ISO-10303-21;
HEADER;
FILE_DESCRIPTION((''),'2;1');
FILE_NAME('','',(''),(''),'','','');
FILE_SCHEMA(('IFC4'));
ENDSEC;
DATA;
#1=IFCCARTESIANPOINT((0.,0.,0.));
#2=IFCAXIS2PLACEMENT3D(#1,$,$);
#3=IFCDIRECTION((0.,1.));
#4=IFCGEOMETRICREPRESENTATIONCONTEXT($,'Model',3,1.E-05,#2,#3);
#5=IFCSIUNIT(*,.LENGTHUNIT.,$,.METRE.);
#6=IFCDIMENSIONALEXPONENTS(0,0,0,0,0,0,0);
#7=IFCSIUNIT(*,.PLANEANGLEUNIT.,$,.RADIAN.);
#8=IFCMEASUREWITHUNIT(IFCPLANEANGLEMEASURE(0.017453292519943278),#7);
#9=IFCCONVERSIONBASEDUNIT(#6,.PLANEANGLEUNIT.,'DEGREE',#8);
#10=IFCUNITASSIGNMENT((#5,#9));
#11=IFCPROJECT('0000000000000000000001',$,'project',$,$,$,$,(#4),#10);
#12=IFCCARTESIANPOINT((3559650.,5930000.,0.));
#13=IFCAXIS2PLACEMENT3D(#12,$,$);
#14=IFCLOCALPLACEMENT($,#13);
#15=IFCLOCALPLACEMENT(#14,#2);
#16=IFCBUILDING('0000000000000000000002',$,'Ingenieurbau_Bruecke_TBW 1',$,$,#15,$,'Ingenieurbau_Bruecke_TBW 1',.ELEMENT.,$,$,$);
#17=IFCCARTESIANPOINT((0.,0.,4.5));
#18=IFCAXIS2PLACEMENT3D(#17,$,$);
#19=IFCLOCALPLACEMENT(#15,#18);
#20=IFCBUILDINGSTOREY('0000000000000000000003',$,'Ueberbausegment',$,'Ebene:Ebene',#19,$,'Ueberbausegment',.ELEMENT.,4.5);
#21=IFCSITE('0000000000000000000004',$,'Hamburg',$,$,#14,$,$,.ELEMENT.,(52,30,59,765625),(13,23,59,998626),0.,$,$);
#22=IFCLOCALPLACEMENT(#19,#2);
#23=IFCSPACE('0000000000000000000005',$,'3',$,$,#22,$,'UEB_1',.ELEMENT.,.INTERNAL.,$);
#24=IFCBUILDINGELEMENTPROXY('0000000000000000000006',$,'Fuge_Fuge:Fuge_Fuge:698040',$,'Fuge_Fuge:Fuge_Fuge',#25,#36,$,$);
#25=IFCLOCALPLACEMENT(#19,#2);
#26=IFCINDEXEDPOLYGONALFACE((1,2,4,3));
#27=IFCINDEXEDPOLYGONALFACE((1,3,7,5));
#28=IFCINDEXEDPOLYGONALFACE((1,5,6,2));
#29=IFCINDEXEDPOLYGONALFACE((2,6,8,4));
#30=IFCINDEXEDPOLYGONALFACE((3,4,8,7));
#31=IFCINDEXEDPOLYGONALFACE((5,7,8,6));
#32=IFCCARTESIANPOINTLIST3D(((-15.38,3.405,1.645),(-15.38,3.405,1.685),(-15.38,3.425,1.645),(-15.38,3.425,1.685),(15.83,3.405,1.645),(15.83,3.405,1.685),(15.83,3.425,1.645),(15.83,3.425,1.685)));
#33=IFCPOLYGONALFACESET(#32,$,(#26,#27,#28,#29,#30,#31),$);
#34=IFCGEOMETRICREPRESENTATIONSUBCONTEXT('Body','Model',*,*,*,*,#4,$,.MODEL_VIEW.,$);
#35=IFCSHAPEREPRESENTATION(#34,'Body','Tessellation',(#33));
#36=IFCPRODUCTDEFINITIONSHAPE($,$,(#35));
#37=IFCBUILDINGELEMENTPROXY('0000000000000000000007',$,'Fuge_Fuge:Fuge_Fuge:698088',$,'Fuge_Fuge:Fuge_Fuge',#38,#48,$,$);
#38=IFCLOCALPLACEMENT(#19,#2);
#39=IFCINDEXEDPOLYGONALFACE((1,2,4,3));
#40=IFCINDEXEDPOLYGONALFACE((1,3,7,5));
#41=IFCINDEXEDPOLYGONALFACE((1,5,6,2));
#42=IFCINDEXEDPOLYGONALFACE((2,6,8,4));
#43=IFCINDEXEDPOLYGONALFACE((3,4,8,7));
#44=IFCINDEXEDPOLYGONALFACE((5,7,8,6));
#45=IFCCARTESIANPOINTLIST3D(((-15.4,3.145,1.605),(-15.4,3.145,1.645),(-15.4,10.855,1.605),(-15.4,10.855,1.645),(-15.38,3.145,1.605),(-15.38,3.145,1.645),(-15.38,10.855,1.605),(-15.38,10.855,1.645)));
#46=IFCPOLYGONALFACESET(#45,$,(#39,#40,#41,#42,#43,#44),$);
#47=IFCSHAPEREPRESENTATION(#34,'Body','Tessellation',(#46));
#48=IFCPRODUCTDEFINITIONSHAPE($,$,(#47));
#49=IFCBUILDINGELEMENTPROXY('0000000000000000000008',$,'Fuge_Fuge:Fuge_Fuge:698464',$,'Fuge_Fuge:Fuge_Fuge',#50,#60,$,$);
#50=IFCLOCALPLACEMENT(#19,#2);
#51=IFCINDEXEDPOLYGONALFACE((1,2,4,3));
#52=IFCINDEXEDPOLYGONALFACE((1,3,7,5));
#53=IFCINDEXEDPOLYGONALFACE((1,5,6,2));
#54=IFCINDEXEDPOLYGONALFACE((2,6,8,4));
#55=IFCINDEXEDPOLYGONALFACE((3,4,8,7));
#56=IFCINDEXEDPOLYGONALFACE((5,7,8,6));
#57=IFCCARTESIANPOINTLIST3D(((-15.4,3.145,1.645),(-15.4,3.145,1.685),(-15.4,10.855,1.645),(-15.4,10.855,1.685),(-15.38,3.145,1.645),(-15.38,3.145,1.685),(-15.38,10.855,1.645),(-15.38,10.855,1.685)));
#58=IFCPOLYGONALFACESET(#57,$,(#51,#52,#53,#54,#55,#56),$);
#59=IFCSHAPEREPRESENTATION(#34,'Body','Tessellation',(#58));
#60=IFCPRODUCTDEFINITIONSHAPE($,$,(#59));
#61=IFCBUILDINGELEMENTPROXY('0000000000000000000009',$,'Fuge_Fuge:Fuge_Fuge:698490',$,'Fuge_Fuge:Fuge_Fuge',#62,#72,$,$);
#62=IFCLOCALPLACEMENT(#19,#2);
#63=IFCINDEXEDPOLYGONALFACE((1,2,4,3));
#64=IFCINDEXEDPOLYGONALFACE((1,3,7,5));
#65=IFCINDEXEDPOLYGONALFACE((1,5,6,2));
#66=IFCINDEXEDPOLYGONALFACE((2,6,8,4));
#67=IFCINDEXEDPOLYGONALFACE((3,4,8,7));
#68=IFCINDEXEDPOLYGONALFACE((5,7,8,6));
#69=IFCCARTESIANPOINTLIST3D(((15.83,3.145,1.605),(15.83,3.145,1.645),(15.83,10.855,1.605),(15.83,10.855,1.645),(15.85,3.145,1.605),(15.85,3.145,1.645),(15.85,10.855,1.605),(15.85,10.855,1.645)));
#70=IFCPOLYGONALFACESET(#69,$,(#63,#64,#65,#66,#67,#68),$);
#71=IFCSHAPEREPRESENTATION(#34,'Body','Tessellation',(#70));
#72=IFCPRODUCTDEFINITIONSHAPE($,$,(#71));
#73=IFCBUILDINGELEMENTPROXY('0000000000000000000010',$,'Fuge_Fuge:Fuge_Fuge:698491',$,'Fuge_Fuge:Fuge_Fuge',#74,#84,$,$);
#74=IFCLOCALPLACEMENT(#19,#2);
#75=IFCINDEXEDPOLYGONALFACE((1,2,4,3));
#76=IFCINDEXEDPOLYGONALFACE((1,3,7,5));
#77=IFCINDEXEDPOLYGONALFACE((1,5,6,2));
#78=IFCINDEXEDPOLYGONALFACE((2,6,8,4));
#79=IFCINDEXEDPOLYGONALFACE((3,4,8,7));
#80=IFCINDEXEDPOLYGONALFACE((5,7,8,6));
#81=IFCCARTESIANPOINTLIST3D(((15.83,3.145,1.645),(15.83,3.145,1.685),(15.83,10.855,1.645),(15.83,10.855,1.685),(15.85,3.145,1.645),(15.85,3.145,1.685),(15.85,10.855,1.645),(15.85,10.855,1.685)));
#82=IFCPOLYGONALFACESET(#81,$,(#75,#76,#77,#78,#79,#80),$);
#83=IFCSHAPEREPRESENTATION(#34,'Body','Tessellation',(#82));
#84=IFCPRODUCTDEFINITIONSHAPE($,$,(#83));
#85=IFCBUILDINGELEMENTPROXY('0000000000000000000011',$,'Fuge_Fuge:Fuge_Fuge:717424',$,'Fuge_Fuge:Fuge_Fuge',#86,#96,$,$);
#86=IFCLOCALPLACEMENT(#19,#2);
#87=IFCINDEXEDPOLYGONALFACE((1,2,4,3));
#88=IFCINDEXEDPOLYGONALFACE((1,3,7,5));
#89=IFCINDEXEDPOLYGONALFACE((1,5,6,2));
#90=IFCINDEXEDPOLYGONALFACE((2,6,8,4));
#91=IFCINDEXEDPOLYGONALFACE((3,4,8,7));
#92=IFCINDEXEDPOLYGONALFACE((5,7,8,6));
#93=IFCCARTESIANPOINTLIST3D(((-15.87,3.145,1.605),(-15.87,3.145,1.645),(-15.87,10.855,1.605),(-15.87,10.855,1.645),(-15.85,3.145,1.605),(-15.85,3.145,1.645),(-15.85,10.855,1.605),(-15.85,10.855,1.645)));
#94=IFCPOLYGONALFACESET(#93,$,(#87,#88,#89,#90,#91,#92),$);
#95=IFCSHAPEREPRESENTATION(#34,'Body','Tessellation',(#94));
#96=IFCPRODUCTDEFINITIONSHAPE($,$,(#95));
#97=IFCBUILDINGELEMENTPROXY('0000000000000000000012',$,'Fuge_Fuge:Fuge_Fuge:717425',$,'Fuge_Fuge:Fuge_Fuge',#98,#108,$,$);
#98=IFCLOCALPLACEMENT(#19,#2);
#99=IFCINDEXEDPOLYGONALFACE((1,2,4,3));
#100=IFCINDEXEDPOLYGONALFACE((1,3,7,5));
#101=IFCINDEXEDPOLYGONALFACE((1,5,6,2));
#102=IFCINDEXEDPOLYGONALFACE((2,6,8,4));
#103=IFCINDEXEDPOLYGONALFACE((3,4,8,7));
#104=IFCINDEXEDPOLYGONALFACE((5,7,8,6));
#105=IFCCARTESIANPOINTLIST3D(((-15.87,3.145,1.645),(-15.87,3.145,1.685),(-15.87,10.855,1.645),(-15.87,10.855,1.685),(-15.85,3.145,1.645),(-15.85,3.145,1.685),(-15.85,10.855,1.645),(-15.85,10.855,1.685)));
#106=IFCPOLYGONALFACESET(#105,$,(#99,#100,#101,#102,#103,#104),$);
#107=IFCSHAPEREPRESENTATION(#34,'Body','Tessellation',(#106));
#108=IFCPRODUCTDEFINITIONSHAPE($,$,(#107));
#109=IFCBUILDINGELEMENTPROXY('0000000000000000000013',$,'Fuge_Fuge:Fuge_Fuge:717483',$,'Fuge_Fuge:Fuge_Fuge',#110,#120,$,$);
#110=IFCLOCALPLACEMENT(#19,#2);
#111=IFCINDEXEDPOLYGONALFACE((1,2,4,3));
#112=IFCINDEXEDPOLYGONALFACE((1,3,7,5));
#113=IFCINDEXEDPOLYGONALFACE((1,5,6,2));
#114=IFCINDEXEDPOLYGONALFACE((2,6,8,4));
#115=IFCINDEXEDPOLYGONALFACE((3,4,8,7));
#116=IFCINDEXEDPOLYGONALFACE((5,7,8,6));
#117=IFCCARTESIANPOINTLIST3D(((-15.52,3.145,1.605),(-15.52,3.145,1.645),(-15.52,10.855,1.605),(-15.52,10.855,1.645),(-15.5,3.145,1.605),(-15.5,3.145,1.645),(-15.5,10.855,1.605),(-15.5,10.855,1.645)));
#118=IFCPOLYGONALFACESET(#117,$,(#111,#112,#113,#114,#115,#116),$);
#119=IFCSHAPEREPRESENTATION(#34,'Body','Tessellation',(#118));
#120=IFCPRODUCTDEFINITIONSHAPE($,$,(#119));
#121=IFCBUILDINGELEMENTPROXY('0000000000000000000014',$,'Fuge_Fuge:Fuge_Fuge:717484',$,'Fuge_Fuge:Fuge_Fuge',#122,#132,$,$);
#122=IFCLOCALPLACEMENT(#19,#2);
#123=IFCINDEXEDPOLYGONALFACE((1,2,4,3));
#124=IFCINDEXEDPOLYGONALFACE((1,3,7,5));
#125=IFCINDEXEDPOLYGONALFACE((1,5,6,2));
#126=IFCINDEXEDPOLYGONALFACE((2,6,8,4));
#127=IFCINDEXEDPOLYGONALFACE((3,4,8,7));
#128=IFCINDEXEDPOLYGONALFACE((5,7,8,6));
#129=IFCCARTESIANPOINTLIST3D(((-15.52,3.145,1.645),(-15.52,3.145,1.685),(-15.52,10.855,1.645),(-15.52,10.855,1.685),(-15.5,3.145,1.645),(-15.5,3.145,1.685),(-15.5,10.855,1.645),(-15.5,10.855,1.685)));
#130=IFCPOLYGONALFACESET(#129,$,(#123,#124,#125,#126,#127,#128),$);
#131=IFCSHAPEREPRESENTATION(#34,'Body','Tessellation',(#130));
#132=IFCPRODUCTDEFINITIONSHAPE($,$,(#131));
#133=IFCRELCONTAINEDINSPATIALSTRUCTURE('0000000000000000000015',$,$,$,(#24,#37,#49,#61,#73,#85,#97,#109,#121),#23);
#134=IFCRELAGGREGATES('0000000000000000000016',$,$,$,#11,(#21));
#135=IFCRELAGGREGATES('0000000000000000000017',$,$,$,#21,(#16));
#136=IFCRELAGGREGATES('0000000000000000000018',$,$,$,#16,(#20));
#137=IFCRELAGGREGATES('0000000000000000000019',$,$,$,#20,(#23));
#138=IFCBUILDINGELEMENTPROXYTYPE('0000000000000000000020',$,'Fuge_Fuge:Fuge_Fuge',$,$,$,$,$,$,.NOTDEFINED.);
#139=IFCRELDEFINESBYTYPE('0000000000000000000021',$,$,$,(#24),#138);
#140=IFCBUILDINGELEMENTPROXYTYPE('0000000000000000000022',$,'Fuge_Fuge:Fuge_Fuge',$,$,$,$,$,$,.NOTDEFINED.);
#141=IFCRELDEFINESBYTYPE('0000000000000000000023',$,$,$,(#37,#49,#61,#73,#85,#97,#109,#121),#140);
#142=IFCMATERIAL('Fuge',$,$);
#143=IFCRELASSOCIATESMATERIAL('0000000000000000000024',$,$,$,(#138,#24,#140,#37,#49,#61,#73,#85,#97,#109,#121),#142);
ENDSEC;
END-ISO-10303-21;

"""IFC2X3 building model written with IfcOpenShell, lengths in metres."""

from ifc_helpers import new_model, entity, si_unit, converted_unit, direction, frame, frame_2d, origin, place, context, subcontext, project, spatial, rectangle, extrude, source, transform, mapped, material, type_object, type_shapes, element, save


model = new_model("IFC2X3")

# Units and contexts
model_context = context("Model", 3, precision=1e-05, world=origin(), true_north=direction((0.0, 1.0)))
body_context = subcontext(model_context, "Body", "Model", "MODEL_VIEW")
ifc_project = project(units=[si_unit("LENGTHUNIT", "METRE"), converted_unit("PLANEANGLEUNIT", "DEGREE", entity("IfcPlaneAngleMeasure", 0.017453292519943278), si_unit("PLANEANGLEUNIT", "RADIAN"), dimensions=[0, 0, 0, 0, 0, 0, 0])], contexts=[model_context])

# Site, building, storey, space
site_placement = place(None, frame((3559650.0, 5930000.0, 0.0)))
site = spatial("IfcSite", under=ifc_project, at=site_placement, Name="Hamburg", CompositionType="ELEMENT", RefLatitude=(52, 30, 59, 765625), RefLongitude=(13, 23, 59, 998626), RefElevation=0.0)
building_placement = place(site_placement, origin())
building = spatial("IfcBuilding", under=site, at=building_placement, Name="Ingenieurbau_Bruecke_TBW 1", LongName="Ingenieurbau_Bruecke_TBW 1", CompositionType="ELEMENT")
storey_placement = place(building_placement, frame((0.0, 0.0, 4.5)))
storey = spatial("IfcBuildingStorey", under=building, at=storey_placement, Name="Ueberbausegment", ObjectType="Ebene:Ebene", LongName="Ueberbausegment", CompositionType="ELEMENT", Elevation=4.5)
space_placement = place(storey_placement, origin())
space = spatial("IfcSpace", under=storey, at=space_placement, Name="3", LongName="UEB_1", CompositionType="ELEMENT", InteriorOrExteriorSpace="INTERNAL")

# Building element proxies
ifc_material_1 = material(Name="Fuge")
building_element_proxy_type_1 = type_object("IfcBuildingElementProxyType", Name="Fuge_Fuge:Fuge_Fuge", PredefinedType="NOTDEFINED", material=ifc_material_1)
shared_shape_1 = source(origin(), body_context, "Body", "SweptSolid", [
    extrude(rectangle(XDim=31.21, YDim=0.02, at=frame_2d((0.0, 0.0), x_axis=(1.0, 0.0))), frame((15.605, 0.01, 0.0), z_axis=(0.0, 0.0, 1.0), x_axis=(-1.0, 0.0, 0.0)), (0.0, 0.0, 1.0), 0.04),
])
type_shapes(building_element_proxy_type_1, [shared_shape_1])
proxy_1_placement = place(space_placement, frame((-15.38, 3.405, 1.645)))
element("IfcBuildingElementProxy", 1, at=proxy_1_placement, inside=space, type_object=building_element_proxy_type_1, material=ifc_material_1, Name="Fuge_Fuge:Fuge_Fuge:698040", ObjectType="Fuge_Fuge:Fuge_Fuge", context=body_context, shape_type="MappedRepresentation", body=[
    mapped(shared_shape_1, transform((0.0, 0.0, 0.0), scale=1.0)),
])
building_element_proxy_type_2 = type_object("IfcBuildingElementProxyType", Name="Fuge_Fuge:Fuge_Fuge", PredefinedType="NOTDEFINED", material=ifc_material_1)
shared_shape_2 = source(origin(), body_context, "Body", "SweptSolid", [
    extrude(rectangle(XDim=7.71, YDim=0.02, at=frame_2d((0.0, 0.0), x_axis=(1.0, 0.0))), frame((3.855, 0.01, 0.0), z_axis=(0.0, 0.0, 1.0), x_axis=(-1.0, 0.0, 0.0)), (0.0, 0.0, 1.0), 0.04),
])
type_shapes(building_element_proxy_type_2, [shared_shape_2])
for number, where, z_axis, x_axis, name in (
    (2, (-15.38, 3.145, 1.605), (0.0, 0.0, 1.0), (0.0, 1.0, 0.0), "Fuge_Fuge:Fuge_Fuge:698088"),
    (3, (-15.38, 3.145, 1.645), (0.0, 0.0, 1.0), (0.0, 1.0, 0.0), "Fuge_Fuge:Fuge_Fuge:698464"),
    (4, (15.85, 3.145, 1.605), (0.0, 0.0, 1.0), (0.0, 1.0, 0.0), "Fuge_Fuge:Fuge_Fuge:698490"),
    (5, (15.85, 3.145, 1.645), (0.0, 0.0, 1.0), (0.0, 1.0, 0.0), "Fuge_Fuge:Fuge_Fuge:698491"),
    (6, (-15.85, 3.145, 1.605), (0.0, 0.0, 1.0), (0.0, 1.0, 0.0), "Fuge_Fuge:Fuge_Fuge:717424"),
    (7, (-15.85, 3.145, 1.645), (0.0, 0.0, 1.0), (0.0, 1.0, 0.0), "Fuge_Fuge:Fuge_Fuge:717425"),
    (8, (-15.5, 3.145, 1.605), (0.0, 0.0, 1.0), (0.0, 1.0, 0.0), "Fuge_Fuge:Fuge_Fuge:717483"),
    (9, (-15.5, 3.145, 1.645), (0.0, 0.0, 1.0), (0.0, 1.0, 0.0), "Fuge_Fuge:Fuge_Fuge:717484"),
):
    element("IfcBuildingElementProxy", number, at=place(space_placement, frame(where, z_axis=z_axis, x_axis=x_axis)), inside=space, type_object=building_element_proxy_type_2, material=ifc_material_1, Name=name, ObjectType="Fuge_Fuge:Fuge_Fuge", context=body_context, shape_type="MappedRepresentation", body=[
        mapped(shared_shape_2, transform((0.0, 0.0, 0.0), scale=1.0)),
    ])

save(model, "model.ifc")
